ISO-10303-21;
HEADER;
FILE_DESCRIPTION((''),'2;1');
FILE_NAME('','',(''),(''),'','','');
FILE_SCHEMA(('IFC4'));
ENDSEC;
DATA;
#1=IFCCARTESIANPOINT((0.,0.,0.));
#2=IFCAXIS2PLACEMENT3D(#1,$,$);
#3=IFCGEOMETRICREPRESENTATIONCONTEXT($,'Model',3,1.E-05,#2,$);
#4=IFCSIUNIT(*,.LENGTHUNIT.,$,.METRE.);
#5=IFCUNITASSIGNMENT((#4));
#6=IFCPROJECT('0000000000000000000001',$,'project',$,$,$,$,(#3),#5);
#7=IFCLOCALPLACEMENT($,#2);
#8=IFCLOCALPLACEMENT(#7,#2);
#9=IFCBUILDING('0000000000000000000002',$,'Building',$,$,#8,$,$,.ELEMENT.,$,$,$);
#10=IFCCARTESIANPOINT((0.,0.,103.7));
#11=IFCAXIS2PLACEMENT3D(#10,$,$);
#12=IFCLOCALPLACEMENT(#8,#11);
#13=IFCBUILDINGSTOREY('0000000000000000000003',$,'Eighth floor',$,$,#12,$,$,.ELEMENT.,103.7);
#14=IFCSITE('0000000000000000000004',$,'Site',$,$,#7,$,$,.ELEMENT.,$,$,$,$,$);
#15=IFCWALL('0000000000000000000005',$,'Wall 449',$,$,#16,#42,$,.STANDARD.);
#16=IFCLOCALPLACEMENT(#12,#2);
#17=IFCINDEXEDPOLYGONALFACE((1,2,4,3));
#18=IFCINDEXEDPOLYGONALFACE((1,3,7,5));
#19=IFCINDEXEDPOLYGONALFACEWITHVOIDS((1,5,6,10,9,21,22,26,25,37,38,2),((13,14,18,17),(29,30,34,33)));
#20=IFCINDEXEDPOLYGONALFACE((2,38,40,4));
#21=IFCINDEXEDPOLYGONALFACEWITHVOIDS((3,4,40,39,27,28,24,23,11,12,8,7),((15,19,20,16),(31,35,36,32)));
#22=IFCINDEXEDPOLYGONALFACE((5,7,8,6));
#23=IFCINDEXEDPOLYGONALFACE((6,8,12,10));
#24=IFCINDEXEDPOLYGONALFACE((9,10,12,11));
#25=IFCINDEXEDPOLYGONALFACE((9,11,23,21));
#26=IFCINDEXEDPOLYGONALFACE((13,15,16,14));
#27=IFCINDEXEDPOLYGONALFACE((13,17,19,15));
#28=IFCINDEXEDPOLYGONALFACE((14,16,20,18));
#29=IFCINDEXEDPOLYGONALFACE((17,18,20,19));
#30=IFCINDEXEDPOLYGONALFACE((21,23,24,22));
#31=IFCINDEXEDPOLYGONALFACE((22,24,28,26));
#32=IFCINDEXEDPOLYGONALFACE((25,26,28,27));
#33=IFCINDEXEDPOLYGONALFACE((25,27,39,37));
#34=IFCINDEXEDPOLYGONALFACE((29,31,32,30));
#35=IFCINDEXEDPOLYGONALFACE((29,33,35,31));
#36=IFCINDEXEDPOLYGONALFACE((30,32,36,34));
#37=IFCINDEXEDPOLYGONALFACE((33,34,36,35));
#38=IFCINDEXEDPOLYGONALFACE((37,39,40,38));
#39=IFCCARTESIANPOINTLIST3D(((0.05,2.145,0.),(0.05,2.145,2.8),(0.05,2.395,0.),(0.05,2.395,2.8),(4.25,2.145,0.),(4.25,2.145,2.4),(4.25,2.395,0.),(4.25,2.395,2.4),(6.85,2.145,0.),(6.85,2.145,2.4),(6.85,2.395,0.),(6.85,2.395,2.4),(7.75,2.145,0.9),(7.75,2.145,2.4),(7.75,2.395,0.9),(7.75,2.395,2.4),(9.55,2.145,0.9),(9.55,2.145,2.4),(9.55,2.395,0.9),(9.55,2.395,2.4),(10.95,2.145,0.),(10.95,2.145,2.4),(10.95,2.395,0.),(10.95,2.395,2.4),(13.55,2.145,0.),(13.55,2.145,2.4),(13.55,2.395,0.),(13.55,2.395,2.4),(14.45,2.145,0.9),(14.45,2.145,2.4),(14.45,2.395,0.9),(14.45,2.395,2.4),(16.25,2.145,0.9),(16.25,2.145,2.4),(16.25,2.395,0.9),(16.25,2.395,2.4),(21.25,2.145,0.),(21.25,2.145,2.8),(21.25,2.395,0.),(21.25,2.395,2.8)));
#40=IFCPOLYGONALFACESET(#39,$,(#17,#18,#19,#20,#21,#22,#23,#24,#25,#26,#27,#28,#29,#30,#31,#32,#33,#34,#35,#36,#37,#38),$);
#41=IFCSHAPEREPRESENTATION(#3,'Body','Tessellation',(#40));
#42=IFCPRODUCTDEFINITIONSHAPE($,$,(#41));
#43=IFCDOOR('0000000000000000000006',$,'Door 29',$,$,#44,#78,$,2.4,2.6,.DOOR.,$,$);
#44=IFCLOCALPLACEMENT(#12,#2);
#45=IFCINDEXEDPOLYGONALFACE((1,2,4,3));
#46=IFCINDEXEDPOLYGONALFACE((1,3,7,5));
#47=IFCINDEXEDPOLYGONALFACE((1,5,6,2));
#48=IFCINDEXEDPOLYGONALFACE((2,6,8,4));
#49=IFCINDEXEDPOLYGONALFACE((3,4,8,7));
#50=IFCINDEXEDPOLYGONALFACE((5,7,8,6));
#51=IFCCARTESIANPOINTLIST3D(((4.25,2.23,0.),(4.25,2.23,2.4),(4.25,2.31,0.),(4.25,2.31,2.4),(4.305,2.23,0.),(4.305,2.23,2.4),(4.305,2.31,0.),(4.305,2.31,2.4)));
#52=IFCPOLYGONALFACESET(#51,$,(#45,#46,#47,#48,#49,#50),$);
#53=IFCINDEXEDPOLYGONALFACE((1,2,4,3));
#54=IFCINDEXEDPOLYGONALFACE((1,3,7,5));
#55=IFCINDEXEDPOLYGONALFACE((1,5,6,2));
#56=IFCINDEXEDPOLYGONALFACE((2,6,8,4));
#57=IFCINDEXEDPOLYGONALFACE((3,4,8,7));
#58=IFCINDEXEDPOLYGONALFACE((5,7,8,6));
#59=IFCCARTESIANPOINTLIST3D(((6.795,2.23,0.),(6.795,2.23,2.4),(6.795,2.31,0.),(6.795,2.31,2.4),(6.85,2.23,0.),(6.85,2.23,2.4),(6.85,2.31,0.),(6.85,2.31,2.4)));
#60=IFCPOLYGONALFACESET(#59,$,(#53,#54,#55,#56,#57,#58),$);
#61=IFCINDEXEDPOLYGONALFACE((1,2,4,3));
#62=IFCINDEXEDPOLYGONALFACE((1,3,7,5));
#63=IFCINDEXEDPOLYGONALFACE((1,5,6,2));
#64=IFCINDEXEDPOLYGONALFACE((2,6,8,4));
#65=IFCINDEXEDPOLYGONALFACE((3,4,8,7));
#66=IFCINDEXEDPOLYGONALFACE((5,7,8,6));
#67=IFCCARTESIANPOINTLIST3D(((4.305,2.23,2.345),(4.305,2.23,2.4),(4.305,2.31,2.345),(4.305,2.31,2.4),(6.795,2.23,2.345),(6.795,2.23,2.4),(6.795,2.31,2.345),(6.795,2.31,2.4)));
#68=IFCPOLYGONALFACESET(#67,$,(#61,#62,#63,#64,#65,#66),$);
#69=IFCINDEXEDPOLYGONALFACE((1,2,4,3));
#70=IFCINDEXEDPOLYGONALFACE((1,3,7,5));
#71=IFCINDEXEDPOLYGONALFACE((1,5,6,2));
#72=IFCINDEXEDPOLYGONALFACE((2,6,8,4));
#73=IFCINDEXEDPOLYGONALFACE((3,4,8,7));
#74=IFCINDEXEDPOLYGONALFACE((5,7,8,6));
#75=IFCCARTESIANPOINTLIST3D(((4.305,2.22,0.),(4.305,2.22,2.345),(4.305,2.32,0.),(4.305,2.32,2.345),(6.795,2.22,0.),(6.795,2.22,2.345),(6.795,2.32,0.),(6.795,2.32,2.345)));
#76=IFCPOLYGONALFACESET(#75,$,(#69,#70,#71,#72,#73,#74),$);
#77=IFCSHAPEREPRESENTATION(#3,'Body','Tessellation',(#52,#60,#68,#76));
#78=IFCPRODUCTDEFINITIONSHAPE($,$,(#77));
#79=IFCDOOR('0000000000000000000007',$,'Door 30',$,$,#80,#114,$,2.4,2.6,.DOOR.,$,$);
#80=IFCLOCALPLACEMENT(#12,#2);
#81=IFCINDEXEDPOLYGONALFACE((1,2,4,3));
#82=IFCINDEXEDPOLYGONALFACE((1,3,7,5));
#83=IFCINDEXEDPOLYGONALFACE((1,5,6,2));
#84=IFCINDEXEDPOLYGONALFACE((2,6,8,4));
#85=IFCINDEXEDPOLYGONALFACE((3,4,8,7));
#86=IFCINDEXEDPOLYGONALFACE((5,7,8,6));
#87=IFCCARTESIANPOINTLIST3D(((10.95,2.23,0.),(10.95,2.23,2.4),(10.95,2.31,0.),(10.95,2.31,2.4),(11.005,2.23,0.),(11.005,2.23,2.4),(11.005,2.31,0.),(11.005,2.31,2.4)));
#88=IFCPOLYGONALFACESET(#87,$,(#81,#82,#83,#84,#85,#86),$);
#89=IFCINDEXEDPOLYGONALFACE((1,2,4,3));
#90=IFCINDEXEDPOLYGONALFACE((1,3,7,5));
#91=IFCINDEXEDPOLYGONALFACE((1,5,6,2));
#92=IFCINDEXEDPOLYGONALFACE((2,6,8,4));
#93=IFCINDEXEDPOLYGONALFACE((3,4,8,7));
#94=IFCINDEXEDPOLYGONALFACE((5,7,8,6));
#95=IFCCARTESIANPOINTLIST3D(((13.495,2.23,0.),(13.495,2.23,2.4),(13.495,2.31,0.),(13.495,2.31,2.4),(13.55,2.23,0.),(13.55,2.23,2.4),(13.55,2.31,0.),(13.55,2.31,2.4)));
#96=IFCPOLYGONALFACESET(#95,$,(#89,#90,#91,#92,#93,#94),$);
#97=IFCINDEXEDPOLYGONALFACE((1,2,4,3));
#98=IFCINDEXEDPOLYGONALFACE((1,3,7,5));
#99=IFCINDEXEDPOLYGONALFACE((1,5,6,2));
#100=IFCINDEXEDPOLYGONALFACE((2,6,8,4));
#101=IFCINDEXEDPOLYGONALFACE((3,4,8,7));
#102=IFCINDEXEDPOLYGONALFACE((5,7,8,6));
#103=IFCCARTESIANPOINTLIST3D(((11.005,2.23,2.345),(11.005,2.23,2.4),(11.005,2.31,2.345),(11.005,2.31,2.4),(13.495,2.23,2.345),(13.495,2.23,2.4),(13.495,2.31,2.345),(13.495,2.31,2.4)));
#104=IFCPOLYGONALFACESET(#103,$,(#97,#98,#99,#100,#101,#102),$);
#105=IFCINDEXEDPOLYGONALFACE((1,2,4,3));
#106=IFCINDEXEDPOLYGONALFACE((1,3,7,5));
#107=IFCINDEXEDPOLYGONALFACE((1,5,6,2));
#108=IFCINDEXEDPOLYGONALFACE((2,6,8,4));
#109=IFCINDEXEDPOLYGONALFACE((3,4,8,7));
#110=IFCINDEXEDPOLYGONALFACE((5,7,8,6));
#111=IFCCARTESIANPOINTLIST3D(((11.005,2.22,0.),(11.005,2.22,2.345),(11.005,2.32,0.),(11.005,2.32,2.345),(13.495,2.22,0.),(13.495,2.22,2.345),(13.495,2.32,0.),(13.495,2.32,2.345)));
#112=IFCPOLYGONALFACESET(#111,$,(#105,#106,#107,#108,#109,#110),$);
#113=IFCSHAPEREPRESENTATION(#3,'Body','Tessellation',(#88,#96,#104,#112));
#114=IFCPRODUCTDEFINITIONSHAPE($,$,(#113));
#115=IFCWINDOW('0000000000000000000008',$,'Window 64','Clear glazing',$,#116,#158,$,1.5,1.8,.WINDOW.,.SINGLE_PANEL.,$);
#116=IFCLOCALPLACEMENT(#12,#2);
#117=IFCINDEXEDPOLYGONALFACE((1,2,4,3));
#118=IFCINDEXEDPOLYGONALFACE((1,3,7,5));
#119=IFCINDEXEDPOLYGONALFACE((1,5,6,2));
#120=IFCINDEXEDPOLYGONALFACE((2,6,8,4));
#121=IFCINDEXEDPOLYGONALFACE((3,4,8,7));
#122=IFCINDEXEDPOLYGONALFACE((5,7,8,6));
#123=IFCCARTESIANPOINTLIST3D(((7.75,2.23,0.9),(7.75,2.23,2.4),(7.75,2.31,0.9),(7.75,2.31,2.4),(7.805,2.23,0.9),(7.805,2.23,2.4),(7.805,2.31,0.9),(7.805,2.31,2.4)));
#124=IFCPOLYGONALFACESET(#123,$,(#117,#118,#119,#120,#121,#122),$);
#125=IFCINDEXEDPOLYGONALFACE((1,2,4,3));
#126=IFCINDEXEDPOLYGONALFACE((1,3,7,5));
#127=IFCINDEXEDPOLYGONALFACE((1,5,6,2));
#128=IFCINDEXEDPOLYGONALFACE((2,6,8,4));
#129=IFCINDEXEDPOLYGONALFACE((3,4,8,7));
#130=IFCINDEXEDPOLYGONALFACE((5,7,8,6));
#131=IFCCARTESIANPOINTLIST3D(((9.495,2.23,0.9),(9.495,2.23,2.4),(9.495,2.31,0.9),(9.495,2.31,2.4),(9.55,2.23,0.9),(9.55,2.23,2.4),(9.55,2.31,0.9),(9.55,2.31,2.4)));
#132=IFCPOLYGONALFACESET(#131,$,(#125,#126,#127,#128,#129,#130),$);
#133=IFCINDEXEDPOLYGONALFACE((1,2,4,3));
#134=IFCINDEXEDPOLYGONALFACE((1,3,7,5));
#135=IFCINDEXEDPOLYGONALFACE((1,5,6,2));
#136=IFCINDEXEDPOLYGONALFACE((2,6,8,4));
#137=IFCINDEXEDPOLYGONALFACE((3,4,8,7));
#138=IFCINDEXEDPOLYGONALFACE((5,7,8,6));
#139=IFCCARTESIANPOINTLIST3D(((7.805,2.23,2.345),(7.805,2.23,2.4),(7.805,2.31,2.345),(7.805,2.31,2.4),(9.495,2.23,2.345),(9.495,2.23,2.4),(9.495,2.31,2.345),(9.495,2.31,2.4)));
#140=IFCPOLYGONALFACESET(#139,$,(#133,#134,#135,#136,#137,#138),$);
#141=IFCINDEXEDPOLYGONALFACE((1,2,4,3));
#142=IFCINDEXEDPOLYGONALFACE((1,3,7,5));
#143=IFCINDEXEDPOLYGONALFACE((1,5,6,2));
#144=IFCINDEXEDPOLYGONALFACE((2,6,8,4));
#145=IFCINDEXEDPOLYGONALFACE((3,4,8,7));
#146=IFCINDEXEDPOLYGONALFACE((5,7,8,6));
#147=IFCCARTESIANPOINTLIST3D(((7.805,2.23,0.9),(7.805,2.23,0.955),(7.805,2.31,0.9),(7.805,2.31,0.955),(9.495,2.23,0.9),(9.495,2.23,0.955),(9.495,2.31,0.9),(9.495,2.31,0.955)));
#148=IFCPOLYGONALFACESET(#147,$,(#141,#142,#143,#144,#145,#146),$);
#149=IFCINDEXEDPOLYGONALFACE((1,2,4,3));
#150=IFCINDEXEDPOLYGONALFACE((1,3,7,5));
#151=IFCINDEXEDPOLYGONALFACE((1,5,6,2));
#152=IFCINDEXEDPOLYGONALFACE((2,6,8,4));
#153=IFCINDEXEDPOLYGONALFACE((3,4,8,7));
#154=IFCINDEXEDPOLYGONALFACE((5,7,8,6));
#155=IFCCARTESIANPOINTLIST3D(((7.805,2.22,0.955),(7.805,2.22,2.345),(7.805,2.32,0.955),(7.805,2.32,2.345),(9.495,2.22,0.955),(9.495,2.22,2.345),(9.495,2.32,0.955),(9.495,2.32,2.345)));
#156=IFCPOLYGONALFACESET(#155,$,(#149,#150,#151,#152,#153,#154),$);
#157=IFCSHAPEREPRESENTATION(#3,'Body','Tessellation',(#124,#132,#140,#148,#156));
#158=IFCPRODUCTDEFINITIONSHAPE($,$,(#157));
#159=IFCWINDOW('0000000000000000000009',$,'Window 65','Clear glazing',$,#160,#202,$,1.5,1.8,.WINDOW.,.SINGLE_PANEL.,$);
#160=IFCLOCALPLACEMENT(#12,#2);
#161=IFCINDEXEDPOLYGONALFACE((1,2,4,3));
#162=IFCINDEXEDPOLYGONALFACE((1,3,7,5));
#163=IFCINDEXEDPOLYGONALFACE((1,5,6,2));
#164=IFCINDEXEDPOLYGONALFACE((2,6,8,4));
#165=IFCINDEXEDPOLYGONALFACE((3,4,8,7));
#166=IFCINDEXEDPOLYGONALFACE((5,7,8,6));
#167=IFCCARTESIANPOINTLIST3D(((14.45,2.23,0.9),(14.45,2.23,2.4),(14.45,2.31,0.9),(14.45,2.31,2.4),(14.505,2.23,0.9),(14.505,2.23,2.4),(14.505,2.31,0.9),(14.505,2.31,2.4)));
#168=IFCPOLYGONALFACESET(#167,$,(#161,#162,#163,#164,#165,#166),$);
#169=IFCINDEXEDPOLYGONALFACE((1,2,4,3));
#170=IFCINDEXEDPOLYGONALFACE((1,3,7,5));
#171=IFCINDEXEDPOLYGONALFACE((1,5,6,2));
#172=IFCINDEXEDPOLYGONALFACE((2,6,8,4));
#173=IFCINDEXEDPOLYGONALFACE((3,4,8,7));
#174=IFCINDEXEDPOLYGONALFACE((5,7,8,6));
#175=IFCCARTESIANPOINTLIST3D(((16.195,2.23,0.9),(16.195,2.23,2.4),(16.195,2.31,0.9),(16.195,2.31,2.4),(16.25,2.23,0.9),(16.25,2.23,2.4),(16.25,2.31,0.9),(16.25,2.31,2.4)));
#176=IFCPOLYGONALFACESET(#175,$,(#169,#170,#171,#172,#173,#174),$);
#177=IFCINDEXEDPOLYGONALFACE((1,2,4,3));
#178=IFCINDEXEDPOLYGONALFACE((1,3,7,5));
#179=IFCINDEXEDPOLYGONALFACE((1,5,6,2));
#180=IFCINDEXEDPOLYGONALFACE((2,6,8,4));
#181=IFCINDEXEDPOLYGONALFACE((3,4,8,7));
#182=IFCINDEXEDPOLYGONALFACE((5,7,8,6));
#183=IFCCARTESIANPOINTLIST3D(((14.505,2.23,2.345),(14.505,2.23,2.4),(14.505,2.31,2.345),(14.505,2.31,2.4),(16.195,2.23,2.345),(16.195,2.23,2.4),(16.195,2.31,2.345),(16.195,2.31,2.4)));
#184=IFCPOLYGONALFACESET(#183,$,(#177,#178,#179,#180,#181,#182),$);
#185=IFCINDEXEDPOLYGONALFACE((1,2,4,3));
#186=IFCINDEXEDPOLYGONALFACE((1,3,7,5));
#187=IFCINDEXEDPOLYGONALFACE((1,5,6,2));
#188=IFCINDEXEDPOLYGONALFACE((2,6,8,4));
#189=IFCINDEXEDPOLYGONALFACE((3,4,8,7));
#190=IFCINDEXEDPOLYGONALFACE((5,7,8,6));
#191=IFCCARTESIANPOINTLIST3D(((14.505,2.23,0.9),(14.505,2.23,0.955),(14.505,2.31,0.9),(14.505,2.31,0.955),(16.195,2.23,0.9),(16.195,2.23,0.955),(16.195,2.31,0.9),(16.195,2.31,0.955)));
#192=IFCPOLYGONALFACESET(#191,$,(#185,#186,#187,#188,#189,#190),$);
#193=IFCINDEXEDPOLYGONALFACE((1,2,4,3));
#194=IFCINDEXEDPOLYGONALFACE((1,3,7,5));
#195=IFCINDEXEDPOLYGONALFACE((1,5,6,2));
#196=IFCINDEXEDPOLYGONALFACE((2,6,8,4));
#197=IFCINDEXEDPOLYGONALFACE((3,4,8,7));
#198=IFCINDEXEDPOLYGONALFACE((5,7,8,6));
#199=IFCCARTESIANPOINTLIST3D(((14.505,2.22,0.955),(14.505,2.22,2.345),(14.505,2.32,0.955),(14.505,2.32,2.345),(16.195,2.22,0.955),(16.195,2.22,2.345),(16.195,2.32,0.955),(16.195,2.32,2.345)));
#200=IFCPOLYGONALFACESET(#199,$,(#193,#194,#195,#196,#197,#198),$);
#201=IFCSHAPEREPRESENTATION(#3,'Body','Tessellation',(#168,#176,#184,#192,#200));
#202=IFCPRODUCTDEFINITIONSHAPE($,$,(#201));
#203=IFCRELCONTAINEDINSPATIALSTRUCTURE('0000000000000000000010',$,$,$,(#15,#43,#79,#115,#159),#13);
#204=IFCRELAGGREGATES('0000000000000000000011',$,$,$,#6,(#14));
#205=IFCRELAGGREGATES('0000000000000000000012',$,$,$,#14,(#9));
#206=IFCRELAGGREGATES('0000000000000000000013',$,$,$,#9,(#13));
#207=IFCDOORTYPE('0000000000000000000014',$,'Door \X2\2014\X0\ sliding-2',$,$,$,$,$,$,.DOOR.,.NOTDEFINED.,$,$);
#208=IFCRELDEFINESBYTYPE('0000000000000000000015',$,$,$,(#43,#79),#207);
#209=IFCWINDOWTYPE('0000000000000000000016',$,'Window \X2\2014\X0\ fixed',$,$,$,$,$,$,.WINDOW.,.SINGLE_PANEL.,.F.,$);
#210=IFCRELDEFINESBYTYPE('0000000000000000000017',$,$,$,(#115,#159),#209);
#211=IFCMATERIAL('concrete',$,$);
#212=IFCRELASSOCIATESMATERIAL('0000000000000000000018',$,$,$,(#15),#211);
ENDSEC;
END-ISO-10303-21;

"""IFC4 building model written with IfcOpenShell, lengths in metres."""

from ifc_helpers import new_model, si_unit, frame, frame_2d, origin, place, context, project, spatial, rectangle, extrude, material, type_object, element, fill, save


model = new_model("IFC4")

# Units and contexts
model_context = context("Model", 3, precision=1e-05, world=origin())
ifc_project = project(units=[si_unit("LENGTHUNIT", "METRE")], contexts=[model_context])

# Site, building, storey
site_placement = place(None, origin())
site = spatial("IfcSite", under=ifc_project, at=site_placement, Name="Site", CompositionType="ELEMENT")
building_placement = place(site_placement, origin())
building = spatial("IfcBuilding", under=site, at=building_placement, Name="Building", CompositionType="ELEMENT")
storey_placement = place(building_placement, frame((0.0, 0.0, 103.7)))
storey = spatial("IfcBuildingStorey", under=building, at=storey_placement, Name="Eighth floor", CompositionType="ELEMENT", Elevation=103.7)

# Shared definitions
ifc_material = material(Name="concrete")

# Wall, openings, doors, windows
wall_1_placement = place(storey_placement, frame((0.05, 2.27, 0.0), z_axis=(0.0, 0.0, 1.0), x_axis=(1.0, 0.0, 0.0)))
wall_1 = element("IfcWall", 1, at=wall_1_placement, inside=storey, material=ifc_material, Name="Wall 449", PredefinedType="STANDARD", context=model_context, shape_type="SweptSolid", body=[
    extrude(rectangle(XDim=21.2, YDim=0.25, at=frame_2d((10.6, 0.0))), origin(), (0.0, 0.0, 1.0), 2.8),
])
opening_1_placement = place(storey_placement, frame((4.25, 2.27, 0.0), z_axis=(0.0, 0.0, 1.0), x_axis=(1.0, 0.0, 0.0)))
opening_1 = element("IfcOpeningElement", 2, at=opening_1_placement, cuts=wall_1, PredefinedType="OPENING", context=model_context, shape_type="SweptSolid", body=[
    extrude(rectangle(XDim=2.6, YDim=0.31, at=frame_2d((1.3, 0.0))), origin(), (0.0, 0.0, 1.0), 2.4),
])
opening_2_placement = place(storey_placement, frame((7.75, 2.27, 0.9), z_axis=(0.0, 0.0, 1.0), x_axis=(1.0, 0.0, 0.0)))
opening_2 = element("IfcOpeningElement", 3, at=opening_2_placement, cuts=wall_1, PredefinedType="OPENING", context=model_context, shape_type="SweptSolid", body=[
    extrude(rectangle(XDim=1.8, YDim=0.31, at=frame_2d((0.9, 0.0))), origin(), (0.0, 0.0, 1.0), 1.5),
])
opening_3_placement = place(storey_placement, frame((10.95, 2.27, 0.0), z_axis=(0.0, 0.0, 1.0), x_axis=(1.0, 0.0, 0.0)))
opening_3 = element("IfcOpeningElement", 4, at=opening_3_placement, cuts=wall_1, PredefinedType="OPENING", context=model_context, shape_type="SweptSolid", body=[
    extrude(rectangle(XDim=2.6, YDim=0.31, at=frame_2d((1.3, 0.0))), origin(), (0.0, 0.0, 1.0), 2.4),
])
opening_4_placement = place(storey_placement, frame((14.45, 2.27, 0.9), z_axis=(0.0, 0.0, 1.0), x_axis=(1.0, 0.0, 0.0)))
opening_4 = element("IfcOpeningElement", 5, at=opening_4_placement, cuts=wall_1, PredefinedType="OPENING", context=model_context, shape_type="SweptSolid", body=[
    extrude(rectangle(XDim=1.8, YDim=0.31, at=frame_2d((0.9, 0.0))), origin(), (0.0, 0.0, 1.0), 1.5),
])
door_type = type_object("IfcDoorType", Name="Door — sliding-2", PredefinedType="DOOR")
door_1_placement = place(storey_placement, frame((4.25, 2.27, 0.0), z_axis=(0.0, 0.0, 1.0), x_axis=(1.0, 0.0, 0.0)))
door_1 = element("IfcDoor", 6, at=door_1_placement, inside=storey, type_object=door_type, Name="Door 29", OverallHeight=2.4, OverallWidth=2.6, PredefinedType="DOOR", context=model_context, shape_type="SweptSolid", body=[
    extrude(rectangle(XDim=0.055, YDim=0.08, at=frame_2d((0.0275, 0.0))), origin(), (0.0, 0.0, 1.0), 2.4),
    extrude(rectangle(XDim=0.055, YDim=0.08, at=frame_2d((2.5725, 0.0))), origin(), (0.0, 0.0, 1.0), 2.4),
    extrude(rectangle(XDim=2.49, YDim=0.08, at=frame_2d((1.3, 0.0))), frame((0.0, 0.0, 2.345)), (0.0, 0.0, 1.0), 0.055),
    extrude(rectangle(XDim=2.49, YDim=0.1, at=frame_2d((1.3, 0.0))), origin(), (0.0, 0.0, 1.0), 2.345),
])
fill(opening_1, door_1)
door_2_placement = place(storey_placement, frame((10.95, 2.27, 0.0), z_axis=(0.0, 0.0, 1.0), x_axis=(1.0, 0.0, 0.0)))
door_2 = element("IfcDoor", 7, at=door_2_placement, inside=storey, type_object=door_type, Name="Door 30", OverallHeight=2.4, OverallWidth=2.6, PredefinedType="DOOR", context=model_context, shape_type="SweptSolid", body=[
    extrude(rectangle(XDim=0.055, YDim=0.08, at=frame_2d((0.0275, 0.0))), origin(), (0.0, 0.0, 1.0), 2.4),
    extrude(rectangle(XDim=0.055, YDim=0.08, at=frame_2d((2.5725, 0.0))), origin(), (0.0, 0.0, 1.0), 2.4),
    extrude(rectangle(XDim=2.49, YDim=0.08, at=frame_2d((1.3, 0.0))), frame((0.0, 0.0, 2.345)), (0.0, 0.0, 1.0), 0.055),
    extrude(rectangle(XDim=2.49, YDim=0.1, at=frame_2d((1.3, 0.0))), origin(), (0.0, 0.0, 1.0), 2.345),
])
fill(opening_3, door_2)
window_type = type_object("IfcWindowType", Name="Window — fixed", ParameterTakesPrecedence=False, PartitioningType="SINGLE_PANEL", PredefinedType="WINDOW")
window_1_placement = place(storey_placement, frame((7.75, 2.27, 0.9), z_axis=(0.0, 0.0, 1.0), x_axis=(1.0, 0.0, 0.0)))
window_1 = element("IfcWindow", 8, at=window_1_placement, inside=storey, type_object=window_type, Name="Window 64", Description="Clear glazing", OverallHeight=1.5, OverallWidth=1.8, PartitioningType="SINGLE_PANEL", PredefinedType="WINDOW", context=model_context, shape_type="SweptSolid", body=[
    extrude(rectangle(XDim=0.055, YDim=0.08, at=frame_2d((0.0275, 0.0))), origin(), (0.0, 0.0, 1.0), 1.5),
    extrude(rectangle(XDim=0.055, YDim=0.08, at=frame_2d((1.7725, 0.0))), origin(), (0.0, 0.0, 1.0), 1.5),
    extrude(rectangle(XDim=1.69, YDim=0.08, at=frame_2d((0.9, 0.0))), frame((0.0, 0.0, 1.445)), (0.0, 0.0, 1.0), 0.055),
    extrude(rectangle(XDim=1.69, YDim=0.08, at=frame_2d((0.9, 0.0))), origin(), (0.0, 0.0, 1.0), 0.055),
    extrude(rectangle(XDim=1.69, YDim=0.1, at=frame_2d((0.9, 0.0))), frame((0.0, 0.0, 0.055)), (0.0, 0.0, 1.0), 1.39),
])
fill(opening_2, window_1)
window_2_placement = place(storey_placement, frame((14.45, 2.27, 0.9), z_axis=(0.0, 0.0, 1.0), x_axis=(1.0, 0.0, 0.0)))
window_2 = element("IfcWindow", 9, at=window_2_placement, inside=storey, type_object=window_type, Name="Window 65", Description="Clear glazing", OverallHeight=1.5, OverallWidth=1.8, PartitioningType="SINGLE_PANEL", PredefinedType="WINDOW", context=model_context, shape_type="SweptSolid", body=[
    extrude(rectangle(XDim=0.055, YDim=0.08, at=frame_2d((0.0275, 0.0))), origin(), (0.0, 0.0, 1.0), 1.5),
    extrude(rectangle(XDim=0.055, YDim=0.08, at=frame_2d((1.7725, 0.0))), origin(), (0.0, 0.0, 1.0), 1.5),
    extrude(rectangle(XDim=1.69, YDim=0.08, at=frame_2d((0.9, 0.0))), frame((0.0, 0.0, 1.445)), (0.0, 0.0, 1.0), 0.055),
    extrude(rectangle(XDim=1.69, YDim=0.08, at=frame_2d((0.9, 0.0))), origin(), (0.0, 0.0, 1.0), 0.055),
    extrude(rectangle(XDim=1.69, YDim=0.1, at=frame_2d((0.9, 0.0))), frame((0.0, 0.0, 0.055)), (0.0, 0.0, 1.0), 1.39),
])
fill(opening_4, window_2)

save(model, "model.ifc")
